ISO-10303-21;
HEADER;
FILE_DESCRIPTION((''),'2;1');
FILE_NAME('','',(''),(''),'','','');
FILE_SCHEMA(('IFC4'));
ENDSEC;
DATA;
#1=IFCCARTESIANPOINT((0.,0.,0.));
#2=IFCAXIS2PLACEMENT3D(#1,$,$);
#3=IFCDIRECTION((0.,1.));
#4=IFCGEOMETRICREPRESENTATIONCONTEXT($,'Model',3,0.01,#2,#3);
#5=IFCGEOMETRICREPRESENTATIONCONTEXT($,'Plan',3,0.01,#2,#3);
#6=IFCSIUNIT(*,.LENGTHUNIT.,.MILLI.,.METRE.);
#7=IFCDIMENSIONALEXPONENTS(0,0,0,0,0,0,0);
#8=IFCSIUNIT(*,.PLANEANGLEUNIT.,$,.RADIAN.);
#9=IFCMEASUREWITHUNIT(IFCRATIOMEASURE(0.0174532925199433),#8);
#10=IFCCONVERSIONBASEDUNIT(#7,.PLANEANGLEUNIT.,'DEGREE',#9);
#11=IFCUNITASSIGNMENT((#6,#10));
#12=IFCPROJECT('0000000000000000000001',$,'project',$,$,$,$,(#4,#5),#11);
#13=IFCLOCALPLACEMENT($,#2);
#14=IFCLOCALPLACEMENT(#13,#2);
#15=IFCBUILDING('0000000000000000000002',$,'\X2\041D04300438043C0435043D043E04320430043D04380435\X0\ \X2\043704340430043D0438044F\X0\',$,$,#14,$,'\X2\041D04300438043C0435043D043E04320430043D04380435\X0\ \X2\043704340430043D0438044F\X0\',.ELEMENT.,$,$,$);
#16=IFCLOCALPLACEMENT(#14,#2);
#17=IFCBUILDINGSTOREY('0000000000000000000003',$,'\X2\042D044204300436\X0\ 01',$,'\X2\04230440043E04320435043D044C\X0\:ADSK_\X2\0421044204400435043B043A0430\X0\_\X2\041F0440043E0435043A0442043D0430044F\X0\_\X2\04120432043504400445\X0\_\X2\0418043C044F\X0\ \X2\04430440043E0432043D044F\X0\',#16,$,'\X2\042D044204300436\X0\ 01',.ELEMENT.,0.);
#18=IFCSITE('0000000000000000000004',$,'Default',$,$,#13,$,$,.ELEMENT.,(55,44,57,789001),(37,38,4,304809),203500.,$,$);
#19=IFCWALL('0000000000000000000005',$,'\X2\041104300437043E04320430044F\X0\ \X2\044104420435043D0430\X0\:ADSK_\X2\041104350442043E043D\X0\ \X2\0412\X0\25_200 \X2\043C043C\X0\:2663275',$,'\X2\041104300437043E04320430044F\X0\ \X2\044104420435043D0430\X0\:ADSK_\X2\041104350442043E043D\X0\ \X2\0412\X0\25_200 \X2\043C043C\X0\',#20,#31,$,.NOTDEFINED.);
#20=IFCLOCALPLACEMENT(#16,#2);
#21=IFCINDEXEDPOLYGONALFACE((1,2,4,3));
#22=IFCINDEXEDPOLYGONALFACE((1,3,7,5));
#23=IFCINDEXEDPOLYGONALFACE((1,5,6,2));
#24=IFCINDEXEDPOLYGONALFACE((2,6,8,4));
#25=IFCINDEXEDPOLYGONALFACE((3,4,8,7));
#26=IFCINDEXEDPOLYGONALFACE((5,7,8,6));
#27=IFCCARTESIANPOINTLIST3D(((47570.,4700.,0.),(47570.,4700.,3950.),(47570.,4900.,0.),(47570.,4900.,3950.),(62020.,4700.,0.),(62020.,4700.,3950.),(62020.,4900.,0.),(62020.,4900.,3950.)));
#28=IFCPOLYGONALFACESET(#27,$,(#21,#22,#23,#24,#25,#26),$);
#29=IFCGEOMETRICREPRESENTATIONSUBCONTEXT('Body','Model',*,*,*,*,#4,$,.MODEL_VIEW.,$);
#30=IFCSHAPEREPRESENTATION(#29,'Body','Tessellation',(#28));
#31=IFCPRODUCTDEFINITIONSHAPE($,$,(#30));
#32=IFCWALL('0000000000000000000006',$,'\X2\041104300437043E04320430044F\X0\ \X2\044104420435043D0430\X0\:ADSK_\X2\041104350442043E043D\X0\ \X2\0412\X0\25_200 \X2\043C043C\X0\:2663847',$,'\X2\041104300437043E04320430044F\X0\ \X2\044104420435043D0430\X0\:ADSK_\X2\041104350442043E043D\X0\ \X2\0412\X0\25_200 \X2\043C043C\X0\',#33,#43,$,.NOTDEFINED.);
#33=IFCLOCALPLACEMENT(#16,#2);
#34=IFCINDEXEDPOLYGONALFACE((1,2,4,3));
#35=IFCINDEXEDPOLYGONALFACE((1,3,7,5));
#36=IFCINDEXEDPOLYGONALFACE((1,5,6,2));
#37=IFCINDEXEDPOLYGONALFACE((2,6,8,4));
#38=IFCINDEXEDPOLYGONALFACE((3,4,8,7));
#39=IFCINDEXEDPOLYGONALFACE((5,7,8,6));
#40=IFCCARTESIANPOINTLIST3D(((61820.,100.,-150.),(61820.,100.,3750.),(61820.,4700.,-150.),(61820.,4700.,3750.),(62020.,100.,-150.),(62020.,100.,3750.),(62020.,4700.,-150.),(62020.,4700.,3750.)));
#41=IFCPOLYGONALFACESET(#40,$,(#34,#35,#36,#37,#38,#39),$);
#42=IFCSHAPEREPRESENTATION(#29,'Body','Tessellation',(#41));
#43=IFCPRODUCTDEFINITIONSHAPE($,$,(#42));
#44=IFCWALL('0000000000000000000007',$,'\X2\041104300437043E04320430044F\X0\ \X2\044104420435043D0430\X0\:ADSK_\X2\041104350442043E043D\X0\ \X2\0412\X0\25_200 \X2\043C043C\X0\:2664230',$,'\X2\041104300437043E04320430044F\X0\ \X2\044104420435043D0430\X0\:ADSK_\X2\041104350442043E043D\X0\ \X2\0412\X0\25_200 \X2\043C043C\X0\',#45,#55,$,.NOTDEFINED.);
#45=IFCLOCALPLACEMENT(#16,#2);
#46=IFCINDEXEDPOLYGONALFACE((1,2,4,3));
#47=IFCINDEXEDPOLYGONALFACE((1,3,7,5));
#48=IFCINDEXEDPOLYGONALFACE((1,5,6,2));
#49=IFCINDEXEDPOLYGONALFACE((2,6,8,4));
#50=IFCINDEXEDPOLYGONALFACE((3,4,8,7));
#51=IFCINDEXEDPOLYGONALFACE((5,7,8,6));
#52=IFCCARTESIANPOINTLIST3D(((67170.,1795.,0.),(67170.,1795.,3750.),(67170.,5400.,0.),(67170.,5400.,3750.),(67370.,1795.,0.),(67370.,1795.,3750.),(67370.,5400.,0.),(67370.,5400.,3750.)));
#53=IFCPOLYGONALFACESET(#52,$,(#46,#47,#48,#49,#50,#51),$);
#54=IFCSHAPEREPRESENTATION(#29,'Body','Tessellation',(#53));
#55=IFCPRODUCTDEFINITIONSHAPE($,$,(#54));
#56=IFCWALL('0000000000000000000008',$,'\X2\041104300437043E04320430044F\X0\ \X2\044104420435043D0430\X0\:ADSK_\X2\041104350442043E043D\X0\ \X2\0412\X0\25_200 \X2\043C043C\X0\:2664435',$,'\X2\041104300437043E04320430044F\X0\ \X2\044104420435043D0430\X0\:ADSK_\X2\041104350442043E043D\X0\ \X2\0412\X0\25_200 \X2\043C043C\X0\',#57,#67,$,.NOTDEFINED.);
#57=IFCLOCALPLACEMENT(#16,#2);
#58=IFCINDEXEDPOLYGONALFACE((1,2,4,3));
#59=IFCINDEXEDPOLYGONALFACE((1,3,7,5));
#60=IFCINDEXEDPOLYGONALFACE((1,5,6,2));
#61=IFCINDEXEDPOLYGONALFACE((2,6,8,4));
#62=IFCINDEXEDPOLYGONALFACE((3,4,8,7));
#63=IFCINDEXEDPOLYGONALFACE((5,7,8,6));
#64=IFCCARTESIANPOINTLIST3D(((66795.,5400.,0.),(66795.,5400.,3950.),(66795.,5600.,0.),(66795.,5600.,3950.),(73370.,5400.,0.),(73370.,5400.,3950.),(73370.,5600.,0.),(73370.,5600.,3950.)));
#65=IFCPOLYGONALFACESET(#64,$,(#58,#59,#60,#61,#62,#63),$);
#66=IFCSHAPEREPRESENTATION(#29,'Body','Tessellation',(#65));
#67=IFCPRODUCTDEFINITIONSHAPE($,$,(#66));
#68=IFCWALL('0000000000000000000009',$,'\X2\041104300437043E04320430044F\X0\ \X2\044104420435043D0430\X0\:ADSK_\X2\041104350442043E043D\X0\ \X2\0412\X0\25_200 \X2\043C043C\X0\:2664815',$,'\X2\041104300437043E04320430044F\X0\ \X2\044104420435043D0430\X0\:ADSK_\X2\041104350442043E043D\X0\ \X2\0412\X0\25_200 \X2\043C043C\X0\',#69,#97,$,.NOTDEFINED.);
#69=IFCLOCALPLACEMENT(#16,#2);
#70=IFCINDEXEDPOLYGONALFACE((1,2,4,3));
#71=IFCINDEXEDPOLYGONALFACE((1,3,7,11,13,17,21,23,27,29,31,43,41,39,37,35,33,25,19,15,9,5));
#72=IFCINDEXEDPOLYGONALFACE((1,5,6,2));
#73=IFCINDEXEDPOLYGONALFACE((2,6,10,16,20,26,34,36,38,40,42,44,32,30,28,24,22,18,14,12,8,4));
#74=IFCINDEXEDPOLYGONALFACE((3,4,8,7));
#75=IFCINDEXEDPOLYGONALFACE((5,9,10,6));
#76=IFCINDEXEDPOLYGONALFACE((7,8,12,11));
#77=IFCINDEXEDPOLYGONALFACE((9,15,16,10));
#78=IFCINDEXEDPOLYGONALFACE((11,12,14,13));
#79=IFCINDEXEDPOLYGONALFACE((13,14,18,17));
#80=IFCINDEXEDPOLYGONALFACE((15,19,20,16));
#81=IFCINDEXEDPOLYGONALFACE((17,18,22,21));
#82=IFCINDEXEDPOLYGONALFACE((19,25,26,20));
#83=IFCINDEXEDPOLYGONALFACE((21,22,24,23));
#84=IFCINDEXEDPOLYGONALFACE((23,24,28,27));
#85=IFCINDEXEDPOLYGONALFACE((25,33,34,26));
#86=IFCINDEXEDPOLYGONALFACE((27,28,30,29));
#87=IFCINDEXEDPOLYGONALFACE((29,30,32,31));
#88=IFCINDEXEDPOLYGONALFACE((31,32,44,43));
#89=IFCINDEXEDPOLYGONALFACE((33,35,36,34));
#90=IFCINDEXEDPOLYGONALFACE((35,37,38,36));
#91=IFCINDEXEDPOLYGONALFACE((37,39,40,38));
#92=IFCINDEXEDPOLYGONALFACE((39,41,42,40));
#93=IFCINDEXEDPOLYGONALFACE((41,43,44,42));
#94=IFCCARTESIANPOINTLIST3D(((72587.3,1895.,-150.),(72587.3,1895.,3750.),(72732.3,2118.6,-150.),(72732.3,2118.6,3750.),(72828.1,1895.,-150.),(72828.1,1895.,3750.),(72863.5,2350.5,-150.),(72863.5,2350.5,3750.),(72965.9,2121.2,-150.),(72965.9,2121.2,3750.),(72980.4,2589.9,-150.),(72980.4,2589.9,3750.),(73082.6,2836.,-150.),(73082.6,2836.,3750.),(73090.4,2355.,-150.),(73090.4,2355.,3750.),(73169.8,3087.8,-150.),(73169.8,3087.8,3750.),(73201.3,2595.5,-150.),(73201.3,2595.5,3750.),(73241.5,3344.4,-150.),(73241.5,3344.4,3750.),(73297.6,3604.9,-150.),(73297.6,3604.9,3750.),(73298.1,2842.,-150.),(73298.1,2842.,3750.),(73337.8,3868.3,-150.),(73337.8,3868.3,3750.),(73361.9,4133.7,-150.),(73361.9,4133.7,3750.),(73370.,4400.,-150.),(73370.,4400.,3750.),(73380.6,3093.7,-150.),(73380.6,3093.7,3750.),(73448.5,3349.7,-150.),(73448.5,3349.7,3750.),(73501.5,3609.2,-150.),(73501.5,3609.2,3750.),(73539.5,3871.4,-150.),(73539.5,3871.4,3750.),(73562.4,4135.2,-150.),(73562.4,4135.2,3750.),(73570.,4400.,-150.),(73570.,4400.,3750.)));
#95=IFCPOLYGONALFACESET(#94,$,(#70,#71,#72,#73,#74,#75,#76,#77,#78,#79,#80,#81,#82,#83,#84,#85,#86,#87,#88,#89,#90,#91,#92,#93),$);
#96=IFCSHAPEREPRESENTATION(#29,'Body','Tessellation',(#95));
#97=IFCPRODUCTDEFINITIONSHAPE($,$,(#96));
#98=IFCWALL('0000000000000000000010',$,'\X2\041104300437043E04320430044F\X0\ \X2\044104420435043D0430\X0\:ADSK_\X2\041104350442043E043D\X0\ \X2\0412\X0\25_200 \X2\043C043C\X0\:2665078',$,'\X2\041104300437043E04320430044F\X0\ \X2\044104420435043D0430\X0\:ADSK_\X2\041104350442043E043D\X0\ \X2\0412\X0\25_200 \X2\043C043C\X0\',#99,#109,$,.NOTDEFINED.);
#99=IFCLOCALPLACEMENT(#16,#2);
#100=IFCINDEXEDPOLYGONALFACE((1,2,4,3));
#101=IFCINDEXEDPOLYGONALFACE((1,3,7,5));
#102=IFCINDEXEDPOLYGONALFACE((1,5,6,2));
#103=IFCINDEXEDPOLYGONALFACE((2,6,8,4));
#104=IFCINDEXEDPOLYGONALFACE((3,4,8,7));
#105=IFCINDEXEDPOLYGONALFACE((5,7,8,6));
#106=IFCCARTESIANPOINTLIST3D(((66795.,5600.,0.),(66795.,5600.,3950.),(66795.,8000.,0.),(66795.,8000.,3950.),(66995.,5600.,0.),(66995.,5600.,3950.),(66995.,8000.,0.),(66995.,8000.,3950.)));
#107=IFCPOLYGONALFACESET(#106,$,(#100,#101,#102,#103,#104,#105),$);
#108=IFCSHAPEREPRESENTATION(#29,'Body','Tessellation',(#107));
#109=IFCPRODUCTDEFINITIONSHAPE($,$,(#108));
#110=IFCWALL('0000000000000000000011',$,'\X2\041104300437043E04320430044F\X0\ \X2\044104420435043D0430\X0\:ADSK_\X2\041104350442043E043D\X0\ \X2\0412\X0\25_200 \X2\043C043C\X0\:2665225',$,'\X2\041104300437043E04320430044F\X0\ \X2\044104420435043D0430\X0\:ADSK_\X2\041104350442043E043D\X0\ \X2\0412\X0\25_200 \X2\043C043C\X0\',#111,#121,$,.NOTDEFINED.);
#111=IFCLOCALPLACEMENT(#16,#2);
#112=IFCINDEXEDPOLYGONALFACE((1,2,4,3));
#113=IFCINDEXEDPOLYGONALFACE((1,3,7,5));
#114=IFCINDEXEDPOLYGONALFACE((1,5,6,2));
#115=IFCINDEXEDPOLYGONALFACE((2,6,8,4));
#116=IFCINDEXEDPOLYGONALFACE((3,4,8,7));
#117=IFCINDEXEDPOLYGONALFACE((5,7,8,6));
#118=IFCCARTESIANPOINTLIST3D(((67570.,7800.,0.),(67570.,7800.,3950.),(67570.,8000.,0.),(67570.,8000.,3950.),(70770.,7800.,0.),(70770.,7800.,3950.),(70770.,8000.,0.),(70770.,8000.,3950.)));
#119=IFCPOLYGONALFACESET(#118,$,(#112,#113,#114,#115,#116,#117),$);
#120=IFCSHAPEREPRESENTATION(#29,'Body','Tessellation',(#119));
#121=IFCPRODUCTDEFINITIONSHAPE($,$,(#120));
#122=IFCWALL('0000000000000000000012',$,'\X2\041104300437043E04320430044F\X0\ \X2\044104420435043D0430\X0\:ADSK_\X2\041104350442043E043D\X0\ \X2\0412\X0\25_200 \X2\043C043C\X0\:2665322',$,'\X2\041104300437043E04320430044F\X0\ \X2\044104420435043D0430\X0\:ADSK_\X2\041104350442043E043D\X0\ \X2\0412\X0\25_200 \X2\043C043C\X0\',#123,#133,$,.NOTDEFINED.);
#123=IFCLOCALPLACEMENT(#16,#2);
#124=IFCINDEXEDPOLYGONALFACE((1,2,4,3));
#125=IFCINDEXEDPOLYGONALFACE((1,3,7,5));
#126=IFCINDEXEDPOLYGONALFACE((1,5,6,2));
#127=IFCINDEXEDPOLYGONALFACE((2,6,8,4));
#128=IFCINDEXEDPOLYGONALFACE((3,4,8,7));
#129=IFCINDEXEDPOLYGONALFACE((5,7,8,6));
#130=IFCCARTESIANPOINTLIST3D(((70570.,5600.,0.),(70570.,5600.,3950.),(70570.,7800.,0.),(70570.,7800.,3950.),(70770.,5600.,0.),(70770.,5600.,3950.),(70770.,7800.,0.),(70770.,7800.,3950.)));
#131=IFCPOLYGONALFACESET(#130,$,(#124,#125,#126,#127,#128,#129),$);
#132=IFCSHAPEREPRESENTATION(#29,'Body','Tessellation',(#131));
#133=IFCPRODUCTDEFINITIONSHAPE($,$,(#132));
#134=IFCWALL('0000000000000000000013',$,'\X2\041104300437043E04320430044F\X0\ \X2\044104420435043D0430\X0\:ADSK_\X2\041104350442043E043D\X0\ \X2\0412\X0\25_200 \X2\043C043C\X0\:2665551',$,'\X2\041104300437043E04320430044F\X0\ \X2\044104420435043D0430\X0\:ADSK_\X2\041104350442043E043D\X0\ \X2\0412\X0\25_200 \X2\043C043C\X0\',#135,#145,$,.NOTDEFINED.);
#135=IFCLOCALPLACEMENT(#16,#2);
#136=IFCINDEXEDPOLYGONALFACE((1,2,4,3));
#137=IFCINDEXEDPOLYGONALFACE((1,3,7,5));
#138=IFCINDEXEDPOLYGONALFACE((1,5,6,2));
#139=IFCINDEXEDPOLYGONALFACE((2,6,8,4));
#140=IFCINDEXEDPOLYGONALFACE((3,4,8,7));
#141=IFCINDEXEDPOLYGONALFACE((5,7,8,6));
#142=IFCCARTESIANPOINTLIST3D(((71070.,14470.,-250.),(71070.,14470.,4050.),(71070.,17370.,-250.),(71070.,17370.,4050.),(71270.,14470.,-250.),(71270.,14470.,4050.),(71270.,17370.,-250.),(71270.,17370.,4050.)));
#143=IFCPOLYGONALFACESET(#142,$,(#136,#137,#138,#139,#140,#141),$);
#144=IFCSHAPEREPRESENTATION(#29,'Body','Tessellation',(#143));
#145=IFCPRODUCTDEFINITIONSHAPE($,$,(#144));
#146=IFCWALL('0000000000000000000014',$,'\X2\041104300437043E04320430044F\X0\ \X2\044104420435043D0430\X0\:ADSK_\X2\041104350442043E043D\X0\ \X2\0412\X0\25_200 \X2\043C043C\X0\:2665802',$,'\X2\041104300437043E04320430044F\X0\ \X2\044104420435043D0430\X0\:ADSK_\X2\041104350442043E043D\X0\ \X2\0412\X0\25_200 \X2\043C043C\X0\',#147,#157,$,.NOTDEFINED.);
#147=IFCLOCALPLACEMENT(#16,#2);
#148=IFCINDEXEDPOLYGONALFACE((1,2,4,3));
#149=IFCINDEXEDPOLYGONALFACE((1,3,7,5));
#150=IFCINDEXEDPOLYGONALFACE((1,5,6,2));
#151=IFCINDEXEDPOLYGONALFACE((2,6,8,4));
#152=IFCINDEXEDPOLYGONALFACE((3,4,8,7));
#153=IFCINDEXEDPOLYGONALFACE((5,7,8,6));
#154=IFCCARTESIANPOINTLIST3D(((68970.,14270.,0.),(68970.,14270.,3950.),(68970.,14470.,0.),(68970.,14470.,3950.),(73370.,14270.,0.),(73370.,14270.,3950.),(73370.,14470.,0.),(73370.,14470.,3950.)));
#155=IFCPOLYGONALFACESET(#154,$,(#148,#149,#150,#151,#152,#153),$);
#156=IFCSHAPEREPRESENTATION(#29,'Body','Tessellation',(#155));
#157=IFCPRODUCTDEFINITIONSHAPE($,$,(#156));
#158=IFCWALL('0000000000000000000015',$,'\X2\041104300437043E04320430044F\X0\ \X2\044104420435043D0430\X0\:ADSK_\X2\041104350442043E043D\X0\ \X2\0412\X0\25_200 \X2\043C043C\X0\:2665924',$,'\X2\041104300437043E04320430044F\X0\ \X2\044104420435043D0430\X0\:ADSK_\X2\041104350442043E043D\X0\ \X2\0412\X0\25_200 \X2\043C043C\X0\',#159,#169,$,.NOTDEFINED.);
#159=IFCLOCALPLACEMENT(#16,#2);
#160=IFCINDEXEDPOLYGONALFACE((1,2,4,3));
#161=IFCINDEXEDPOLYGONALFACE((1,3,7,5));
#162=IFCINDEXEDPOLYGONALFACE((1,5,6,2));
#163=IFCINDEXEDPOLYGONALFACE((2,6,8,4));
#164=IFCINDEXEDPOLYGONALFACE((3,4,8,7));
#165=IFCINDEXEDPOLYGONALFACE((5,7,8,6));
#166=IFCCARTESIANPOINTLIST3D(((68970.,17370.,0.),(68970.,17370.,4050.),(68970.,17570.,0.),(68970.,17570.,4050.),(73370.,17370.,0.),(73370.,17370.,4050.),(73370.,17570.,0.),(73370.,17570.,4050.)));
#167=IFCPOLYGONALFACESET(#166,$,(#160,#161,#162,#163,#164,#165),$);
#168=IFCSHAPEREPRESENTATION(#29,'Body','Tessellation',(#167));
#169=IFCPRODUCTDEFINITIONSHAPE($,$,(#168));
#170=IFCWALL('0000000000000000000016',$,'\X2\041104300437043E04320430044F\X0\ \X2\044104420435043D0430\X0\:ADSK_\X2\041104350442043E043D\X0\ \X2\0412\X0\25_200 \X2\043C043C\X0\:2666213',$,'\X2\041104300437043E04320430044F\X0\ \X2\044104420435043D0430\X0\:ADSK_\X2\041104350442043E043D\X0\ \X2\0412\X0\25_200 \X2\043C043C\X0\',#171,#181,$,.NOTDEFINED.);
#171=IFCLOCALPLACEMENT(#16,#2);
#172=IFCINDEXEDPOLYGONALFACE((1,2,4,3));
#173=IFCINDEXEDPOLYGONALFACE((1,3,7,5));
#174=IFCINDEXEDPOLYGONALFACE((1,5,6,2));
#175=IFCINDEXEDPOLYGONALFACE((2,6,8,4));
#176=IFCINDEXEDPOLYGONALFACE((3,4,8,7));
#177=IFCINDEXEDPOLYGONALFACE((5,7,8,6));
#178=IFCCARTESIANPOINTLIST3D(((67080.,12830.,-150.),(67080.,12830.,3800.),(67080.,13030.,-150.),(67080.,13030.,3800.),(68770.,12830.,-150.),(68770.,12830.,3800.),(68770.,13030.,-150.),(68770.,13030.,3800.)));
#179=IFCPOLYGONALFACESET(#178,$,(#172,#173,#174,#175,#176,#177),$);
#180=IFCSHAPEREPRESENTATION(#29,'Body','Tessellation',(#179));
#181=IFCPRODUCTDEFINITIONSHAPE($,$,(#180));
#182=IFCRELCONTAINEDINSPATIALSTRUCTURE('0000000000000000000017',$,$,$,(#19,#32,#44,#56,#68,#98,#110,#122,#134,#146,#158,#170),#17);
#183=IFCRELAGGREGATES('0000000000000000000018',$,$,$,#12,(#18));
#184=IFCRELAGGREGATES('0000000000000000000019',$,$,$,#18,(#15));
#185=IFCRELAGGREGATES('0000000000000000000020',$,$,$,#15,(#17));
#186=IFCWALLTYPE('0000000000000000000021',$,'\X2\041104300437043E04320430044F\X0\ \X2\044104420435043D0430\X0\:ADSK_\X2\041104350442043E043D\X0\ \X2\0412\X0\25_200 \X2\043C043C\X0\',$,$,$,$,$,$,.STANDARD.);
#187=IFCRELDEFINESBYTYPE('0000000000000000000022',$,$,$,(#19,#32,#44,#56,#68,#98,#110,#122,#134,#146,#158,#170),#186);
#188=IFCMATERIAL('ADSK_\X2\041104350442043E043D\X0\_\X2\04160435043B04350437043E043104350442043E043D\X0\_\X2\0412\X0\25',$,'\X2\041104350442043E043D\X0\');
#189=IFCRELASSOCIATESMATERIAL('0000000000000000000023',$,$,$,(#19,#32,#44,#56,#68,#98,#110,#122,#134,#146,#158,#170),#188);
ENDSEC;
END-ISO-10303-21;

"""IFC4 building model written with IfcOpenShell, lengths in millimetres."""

from ifc_helpers import new_model, entity, si_unit, converted_unit, direction, frame, origin, place, context, subcontext, project, spatial, indexed_curve, outline, extrude, material, type_object, element, save


model = new_model("IFC4")

# Units and contexts
model_context = context("Model", 3, precision=0.01, world=origin(), true_north=direction((0.0, 1.0)))
plan_context = context("Plan", 3, precision=0.01, world=origin(), true_north=direction((0.0, 1.0)))
body_context = subcontext(model_context, "Body", "Model", "MODEL_VIEW")
ifc_project = project(units=[si_unit("LENGTHUNIT", "METRE", prefix="MILLI"), converted_unit("PLANEANGLEUNIT", "DEGREE", entity("IfcRatioMeasure", 0.0174532925199433), si_unit("PLANEANGLEUNIT", "RADIAN"), dimensions=[0, 0, 0, 0, 0, 0, 0])], contexts=[model_context, plan_context])

# Site, building, storey
site_placement = place(None, origin())
site = spatial("IfcSite", under=ifc_project, at=site_placement, Name="Default", CompositionType="ELEMENT", RefLatitude=(55, 44, 57, 789001), RefLongitude=(37, 38, 4, 304809), RefElevation=203500.0)
building_placement = place(site_placement, origin())
building = spatial("IfcBuilding", under=site, at=building_placement, Name="Наименование здания", LongName="Наименование здания", CompositionType="ELEMENT")
storey_placement = place(building_placement, origin())
storey = spatial("IfcBuildingStorey", under=building, at=storey_placement, Name="Этаж 01", ObjectType="Уровень:ADSK_Стрелка_Проектная_Вверх_Имя уровня", LongName="Этаж 01", CompositionType="ELEMENT", Elevation=0.0)

# Walls
ifc_material = material(Name="ADSK_Бетон_Железобетон_В25", Category="Бетон")
wall_type_1 = type_object("IfcWallType", Name="Базовая стена:ADSK_Бетон В25_200 мм", PredefinedType="STANDARD")
wall_1_placement = place(storey_placement, frame((62020.0, 4800.0, 0.0), z_axis=(0.0, 0.0, 1.0), x_axis=(-1.0, 0.0, 0.0)))
element("IfcWall", 1, at=wall_1_placement, inside=storey, type_object=wall_type_1, material=ifc_material, Name="Базовая стена:ADSK_Бетон В25_200 мм:2663275", ObjectType="Базовая стена:ADSK_Бетон В25_200 мм", PredefinedType="NOTDEFINED", context=body_context, shape_type="SweptSolid", body=[
    extrude(outline(indexed_curve([(14450.0, 100.0), (0.0, 100.0), (0.0, -100.0), (14450.0, -100.0), (14450.0, 100.0)], self_intersect=False)), origin(), (0.0, 0.0, 1.0), 3950.0),
])
wall_2_placement = place(storey_placement, frame((61920.0, 4700.0, -150.0), z_axis=(0.0, 0.0, 1.0), x_axis=(0.0, -1.0, 0.0)))
element("IfcWall", 2, at=wall_2_placement, inside=storey, type_object=wall_type_1, material=ifc_material, Name="Базовая стена:ADSK_Бетон В25_200 мм:2663847", ObjectType="Базовая стена:ADSK_Бетон В25_200 мм", PredefinedType="NOTDEFINED", context=body_context, shape_type="SweptSolid", body=[
    extrude(outline(indexed_curve([(4600.0, 100.0), (0.0, 100.0), (0.0, -100.0), (4600.0, -100.0), (4600.0, 100.0)], self_intersect=False)), origin(), (0.0, 0.0, 1.0), 3900.0),
])
wall_3_placement = place(storey_placement, frame((67270.0, 1795.0, 0.0), z_axis=(0.0, 0.0, 1.0), x_axis=(0.0, 1.0, 0.0)))
element("IfcWall", 3, at=wall_3_placement, inside=storey, type_object=wall_type_1, material=ifc_material, Name="Базовая стена:ADSK_Бетон В25_200 мм:2664230", ObjectType="Базовая стена:ADSK_Бетон В25_200 мм", PredefinedType="NOTDEFINED", context=body_context, shape_type="SweptSolid", body=[
    extrude(outline(indexed_curve([(3605.0, 100.0), (0.0, 100.0), (0.0, -100.0), (3605.0, -100.0), (3605.0, 100.0)], self_intersect=False)), origin(), (0.0, 0.0, 1.0), 3750.0),
])
wall_4_placement = place(storey_placement, frame((66795.0, 5500.0, 0.0)))
element("IfcWall", 4, at=wall_4_placement, inside=storey, type_object=wall_type_1, material=ifc_material, Name="Базовая стена:ADSK_Бетон В25_200 мм:2664435", ObjectType="Базовая стена:ADSK_Бетон В25_200 мм", PredefinedType="NOTDEFINED", context=body_context, shape_type="SweptSolid", body=[
    extrude(outline(indexed_curve([(6575.0, 100.0), (0.0, 100.0), (0.0, -100.0), (6575.0, -100.0), (6575.0, 100.0)], self_intersect=False)), origin(), (0.0, 0.0, 1.0), 3950.0),
])
wall_5_placement = place(storey_placement, frame((73470.0, 4400.0, -150.0)))
element("IfcWall", 5, at=wall_5_placement, inside=storey, type_object=wall_type_1, material=ifc_material, Name="Базовая стена:ADSK_Бетон В25_200 мм:2664815", ObjectType="Базовая стена:ADSK_Бетон В25_200 мм", PredefinedType="NOTDEFINED", context=body_context, shape_type="SweptSolid", body=[
    extrude(outline(indexed_curve([(-641.9, -2505.0), (-504.1, -2278.8), (-379.6, -2045.0), (-268.7, -1804.5), (-171.9, -1558.0), (-89.4, -1306.3), (-21.5, -1050.3), (31.5, -790.8), (69.5, -528.6), (92.4, -264.8), (100.0, 0.0), (-100.0, 0.0), (-108.1, -266.3), (-132.2, -531.7), (-172.4, -795.1), (-228.5, -1055.6), (-300.2, -1312.2), (-387.4, -1564.0), (-489.6, -1810.1), (-606.5, -2049.5), (-737.7, -2281.4), (-882.7, -2505.0), (-641.9, -2505.0)], self_intersect=False)), origin(), (0.0, 0.0, 1.0), 3900.0),
])
wall_6_placement = place(storey_placement, frame((66895.0, 8000.0, 0.0), z_axis=(0.0, 0.0, 1.0), x_axis=(0.0, -1.0, 0.0)))
element("IfcWall", 6, at=wall_6_placement, inside=storey, type_object=wall_type_1, material=ifc_material, Name="Базовая стена:ADSK_Бетон В25_200 мм:2665078", ObjectType="Базовая стена:ADSK_Бетон В25_200 мм", PredefinedType="NOTDEFINED", context=body_context, shape_type="SweptSolid", body=[
    extrude(outline(indexed_curve([(2400.0, 100.0), (0.0, 100.0), (0.0, -100.0), (2400.0, -100.0), (2400.0, 100.0)], self_intersect=False)), origin(), (0.0, 0.0, 1.0), 3950.0),
])
wall_7_placement = place(storey_placement, frame((67570.0, 7900.0, 0.0)))
element("IfcWall", 7, at=wall_7_placement, inside=storey, type_object=wall_type_1, material=ifc_material, Name="Базовая стена:ADSK_Бетон В25_200 мм:2665225", ObjectType="Базовая стена:ADSK_Бетон В25_200 мм", PredefinedType="NOTDEFINED", context=body_context, shape_type="SweptSolid", body=[
    extrude(outline(indexed_curve([(3200.0, 100.0), (0.0, 100.0), (0.0, -100.0), (3200.0, -100.0), (3200.0, 100.0)], self_intersect=False)), origin(), (0.0, 0.0, 1.0), 3950.0),
])
wall_8_placement = place(storey_placement, frame((70670.0, 7800.0, 0.0), z_axis=(0.0, 0.0, 1.0), x_axis=(0.0, -1.0, 0.0)))
element("IfcWall", 8, at=wall_8_placement, inside=storey, type_object=wall_type_1, material=ifc_material, Name="Базовая стена:ADSK_Бетон В25_200 мм:2665322", ObjectType="Базовая стена:ADSK_Бетон В25_200 мм", PredefinedType="NOTDEFINED", context=body_context, shape_type="SweptSolid", body=[
    extrude(outline(indexed_curve([(2200.0, 100.0), (0.0, 100.0), (0.0, -100.0), (2200.0, -100.0), (2200.0, 100.0)], self_intersect=False)), origin(), (0.0, 0.0, 1.0), 3950.0),
])
wall_9_placement = place(storey_placement, frame((71170.0, 17370.0, -250.0), z_axis=(0.0, 0.0, 1.0), x_axis=(0.0, -1.0, 0.0)))
element("IfcWall", 9, at=wall_9_placement, inside=storey, type_object=wall_type_1, material=ifc_material, Name="Базовая стена:ADSK_Бетон В25_200 мм:2665551", ObjectType="Базовая стена:ADSK_Бетон В25_200 мм", PredefinedType="NOTDEFINED", context=body_context, shape_type="SweptSolid", body=[
    extrude(outline(indexed_curve([(2900.0, 100.0), (0.0, 100.0), (0.0, -100.0), (2900.0, -100.0), (2900.0, 100.0)], self_intersect=False)), origin(), (0.0, 0.0, 1.0), 4300.0),
])
wall_10_placement = place(storey_placement, frame((73370.0, 14370.0, 0.0), z_axis=(0.0, 0.0, 1.0), x_axis=(-1.0, 0.0, 0.0)))
element("IfcWall", 10, at=wall_10_placement, inside=storey, type_object=wall_type_1, material=ifc_material, Name="Базовая стена:ADSK_Бетон В25_200 мм:2665802", ObjectType="Базовая стена:ADSK_Бетон В25_200 мм", PredefinedType="NOTDEFINED", context=body_context, shape_type="SweptSolid", body=[
    extrude(outline(indexed_curve([(4400.0, 100.0), (0.0, 100.0), (0.0, -100.0), (4400.0, -100.0), (4400.0, 100.0)], self_intersect=False)), origin(), (0.0, 0.0, 1.0), 3950.0),
])
wall_11_placement = place(storey_placement, frame((73370.0, 17470.0, 0.0), z_axis=(0.0, 0.0, 1.0), x_axis=(-1.0, 0.0, 0.0)))
element("IfcWall", 11, at=wall_11_placement, inside=storey, type_object=wall_type_1, material=ifc_material, Name="Базовая стена:ADSK_Бетон В25_200 мм:2665924", ObjectType="Базовая стена:ADSK_Бетон В25_200 мм", PredefinedType="NOTDEFINED", context=body_context, shape_type="SweptSolid", body=[
    extrude(outline(indexed_curve([(4400.0, 100.0), (0.0, 100.0), (0.0, -100.0), (4400.0, -100.0), (4400.0, 100.0)], self_intersect=False)), origin(), (0.0, 0.0, 1.0), 4050.0),
])
wall_12_placement = place(storey_placement, frame((68770.0, 12930.0, -150.0), z_axis=(0.0, 0.0, 1.0), x_axis=(-1.0, 0.0, 0.0)))
element("IfcWall", 12, at=wall_12_placement, inside=storey, type_object=wall_type_1, material=ifc_material, Name="Базовая стена:ADSK_Бетон В25_200 мм:2666213", ObjectType="Базовая стена:ADSK_Бетон В25_200 мм", PredefinedType="NOTDEFINED", context=body_context, shape_type="SweptSolid", body=[
    extrude(outline(indexed_curve([(1690.0, 100.0), (0.0, 100.0), (0.0, -100.0), (1690.0, -100.0), (1690.0, 100.0)], self_intersect=False)), origin(), (0.0, 0.0, 1.0), 3950.0),
])

save(model, "model.ifc")
